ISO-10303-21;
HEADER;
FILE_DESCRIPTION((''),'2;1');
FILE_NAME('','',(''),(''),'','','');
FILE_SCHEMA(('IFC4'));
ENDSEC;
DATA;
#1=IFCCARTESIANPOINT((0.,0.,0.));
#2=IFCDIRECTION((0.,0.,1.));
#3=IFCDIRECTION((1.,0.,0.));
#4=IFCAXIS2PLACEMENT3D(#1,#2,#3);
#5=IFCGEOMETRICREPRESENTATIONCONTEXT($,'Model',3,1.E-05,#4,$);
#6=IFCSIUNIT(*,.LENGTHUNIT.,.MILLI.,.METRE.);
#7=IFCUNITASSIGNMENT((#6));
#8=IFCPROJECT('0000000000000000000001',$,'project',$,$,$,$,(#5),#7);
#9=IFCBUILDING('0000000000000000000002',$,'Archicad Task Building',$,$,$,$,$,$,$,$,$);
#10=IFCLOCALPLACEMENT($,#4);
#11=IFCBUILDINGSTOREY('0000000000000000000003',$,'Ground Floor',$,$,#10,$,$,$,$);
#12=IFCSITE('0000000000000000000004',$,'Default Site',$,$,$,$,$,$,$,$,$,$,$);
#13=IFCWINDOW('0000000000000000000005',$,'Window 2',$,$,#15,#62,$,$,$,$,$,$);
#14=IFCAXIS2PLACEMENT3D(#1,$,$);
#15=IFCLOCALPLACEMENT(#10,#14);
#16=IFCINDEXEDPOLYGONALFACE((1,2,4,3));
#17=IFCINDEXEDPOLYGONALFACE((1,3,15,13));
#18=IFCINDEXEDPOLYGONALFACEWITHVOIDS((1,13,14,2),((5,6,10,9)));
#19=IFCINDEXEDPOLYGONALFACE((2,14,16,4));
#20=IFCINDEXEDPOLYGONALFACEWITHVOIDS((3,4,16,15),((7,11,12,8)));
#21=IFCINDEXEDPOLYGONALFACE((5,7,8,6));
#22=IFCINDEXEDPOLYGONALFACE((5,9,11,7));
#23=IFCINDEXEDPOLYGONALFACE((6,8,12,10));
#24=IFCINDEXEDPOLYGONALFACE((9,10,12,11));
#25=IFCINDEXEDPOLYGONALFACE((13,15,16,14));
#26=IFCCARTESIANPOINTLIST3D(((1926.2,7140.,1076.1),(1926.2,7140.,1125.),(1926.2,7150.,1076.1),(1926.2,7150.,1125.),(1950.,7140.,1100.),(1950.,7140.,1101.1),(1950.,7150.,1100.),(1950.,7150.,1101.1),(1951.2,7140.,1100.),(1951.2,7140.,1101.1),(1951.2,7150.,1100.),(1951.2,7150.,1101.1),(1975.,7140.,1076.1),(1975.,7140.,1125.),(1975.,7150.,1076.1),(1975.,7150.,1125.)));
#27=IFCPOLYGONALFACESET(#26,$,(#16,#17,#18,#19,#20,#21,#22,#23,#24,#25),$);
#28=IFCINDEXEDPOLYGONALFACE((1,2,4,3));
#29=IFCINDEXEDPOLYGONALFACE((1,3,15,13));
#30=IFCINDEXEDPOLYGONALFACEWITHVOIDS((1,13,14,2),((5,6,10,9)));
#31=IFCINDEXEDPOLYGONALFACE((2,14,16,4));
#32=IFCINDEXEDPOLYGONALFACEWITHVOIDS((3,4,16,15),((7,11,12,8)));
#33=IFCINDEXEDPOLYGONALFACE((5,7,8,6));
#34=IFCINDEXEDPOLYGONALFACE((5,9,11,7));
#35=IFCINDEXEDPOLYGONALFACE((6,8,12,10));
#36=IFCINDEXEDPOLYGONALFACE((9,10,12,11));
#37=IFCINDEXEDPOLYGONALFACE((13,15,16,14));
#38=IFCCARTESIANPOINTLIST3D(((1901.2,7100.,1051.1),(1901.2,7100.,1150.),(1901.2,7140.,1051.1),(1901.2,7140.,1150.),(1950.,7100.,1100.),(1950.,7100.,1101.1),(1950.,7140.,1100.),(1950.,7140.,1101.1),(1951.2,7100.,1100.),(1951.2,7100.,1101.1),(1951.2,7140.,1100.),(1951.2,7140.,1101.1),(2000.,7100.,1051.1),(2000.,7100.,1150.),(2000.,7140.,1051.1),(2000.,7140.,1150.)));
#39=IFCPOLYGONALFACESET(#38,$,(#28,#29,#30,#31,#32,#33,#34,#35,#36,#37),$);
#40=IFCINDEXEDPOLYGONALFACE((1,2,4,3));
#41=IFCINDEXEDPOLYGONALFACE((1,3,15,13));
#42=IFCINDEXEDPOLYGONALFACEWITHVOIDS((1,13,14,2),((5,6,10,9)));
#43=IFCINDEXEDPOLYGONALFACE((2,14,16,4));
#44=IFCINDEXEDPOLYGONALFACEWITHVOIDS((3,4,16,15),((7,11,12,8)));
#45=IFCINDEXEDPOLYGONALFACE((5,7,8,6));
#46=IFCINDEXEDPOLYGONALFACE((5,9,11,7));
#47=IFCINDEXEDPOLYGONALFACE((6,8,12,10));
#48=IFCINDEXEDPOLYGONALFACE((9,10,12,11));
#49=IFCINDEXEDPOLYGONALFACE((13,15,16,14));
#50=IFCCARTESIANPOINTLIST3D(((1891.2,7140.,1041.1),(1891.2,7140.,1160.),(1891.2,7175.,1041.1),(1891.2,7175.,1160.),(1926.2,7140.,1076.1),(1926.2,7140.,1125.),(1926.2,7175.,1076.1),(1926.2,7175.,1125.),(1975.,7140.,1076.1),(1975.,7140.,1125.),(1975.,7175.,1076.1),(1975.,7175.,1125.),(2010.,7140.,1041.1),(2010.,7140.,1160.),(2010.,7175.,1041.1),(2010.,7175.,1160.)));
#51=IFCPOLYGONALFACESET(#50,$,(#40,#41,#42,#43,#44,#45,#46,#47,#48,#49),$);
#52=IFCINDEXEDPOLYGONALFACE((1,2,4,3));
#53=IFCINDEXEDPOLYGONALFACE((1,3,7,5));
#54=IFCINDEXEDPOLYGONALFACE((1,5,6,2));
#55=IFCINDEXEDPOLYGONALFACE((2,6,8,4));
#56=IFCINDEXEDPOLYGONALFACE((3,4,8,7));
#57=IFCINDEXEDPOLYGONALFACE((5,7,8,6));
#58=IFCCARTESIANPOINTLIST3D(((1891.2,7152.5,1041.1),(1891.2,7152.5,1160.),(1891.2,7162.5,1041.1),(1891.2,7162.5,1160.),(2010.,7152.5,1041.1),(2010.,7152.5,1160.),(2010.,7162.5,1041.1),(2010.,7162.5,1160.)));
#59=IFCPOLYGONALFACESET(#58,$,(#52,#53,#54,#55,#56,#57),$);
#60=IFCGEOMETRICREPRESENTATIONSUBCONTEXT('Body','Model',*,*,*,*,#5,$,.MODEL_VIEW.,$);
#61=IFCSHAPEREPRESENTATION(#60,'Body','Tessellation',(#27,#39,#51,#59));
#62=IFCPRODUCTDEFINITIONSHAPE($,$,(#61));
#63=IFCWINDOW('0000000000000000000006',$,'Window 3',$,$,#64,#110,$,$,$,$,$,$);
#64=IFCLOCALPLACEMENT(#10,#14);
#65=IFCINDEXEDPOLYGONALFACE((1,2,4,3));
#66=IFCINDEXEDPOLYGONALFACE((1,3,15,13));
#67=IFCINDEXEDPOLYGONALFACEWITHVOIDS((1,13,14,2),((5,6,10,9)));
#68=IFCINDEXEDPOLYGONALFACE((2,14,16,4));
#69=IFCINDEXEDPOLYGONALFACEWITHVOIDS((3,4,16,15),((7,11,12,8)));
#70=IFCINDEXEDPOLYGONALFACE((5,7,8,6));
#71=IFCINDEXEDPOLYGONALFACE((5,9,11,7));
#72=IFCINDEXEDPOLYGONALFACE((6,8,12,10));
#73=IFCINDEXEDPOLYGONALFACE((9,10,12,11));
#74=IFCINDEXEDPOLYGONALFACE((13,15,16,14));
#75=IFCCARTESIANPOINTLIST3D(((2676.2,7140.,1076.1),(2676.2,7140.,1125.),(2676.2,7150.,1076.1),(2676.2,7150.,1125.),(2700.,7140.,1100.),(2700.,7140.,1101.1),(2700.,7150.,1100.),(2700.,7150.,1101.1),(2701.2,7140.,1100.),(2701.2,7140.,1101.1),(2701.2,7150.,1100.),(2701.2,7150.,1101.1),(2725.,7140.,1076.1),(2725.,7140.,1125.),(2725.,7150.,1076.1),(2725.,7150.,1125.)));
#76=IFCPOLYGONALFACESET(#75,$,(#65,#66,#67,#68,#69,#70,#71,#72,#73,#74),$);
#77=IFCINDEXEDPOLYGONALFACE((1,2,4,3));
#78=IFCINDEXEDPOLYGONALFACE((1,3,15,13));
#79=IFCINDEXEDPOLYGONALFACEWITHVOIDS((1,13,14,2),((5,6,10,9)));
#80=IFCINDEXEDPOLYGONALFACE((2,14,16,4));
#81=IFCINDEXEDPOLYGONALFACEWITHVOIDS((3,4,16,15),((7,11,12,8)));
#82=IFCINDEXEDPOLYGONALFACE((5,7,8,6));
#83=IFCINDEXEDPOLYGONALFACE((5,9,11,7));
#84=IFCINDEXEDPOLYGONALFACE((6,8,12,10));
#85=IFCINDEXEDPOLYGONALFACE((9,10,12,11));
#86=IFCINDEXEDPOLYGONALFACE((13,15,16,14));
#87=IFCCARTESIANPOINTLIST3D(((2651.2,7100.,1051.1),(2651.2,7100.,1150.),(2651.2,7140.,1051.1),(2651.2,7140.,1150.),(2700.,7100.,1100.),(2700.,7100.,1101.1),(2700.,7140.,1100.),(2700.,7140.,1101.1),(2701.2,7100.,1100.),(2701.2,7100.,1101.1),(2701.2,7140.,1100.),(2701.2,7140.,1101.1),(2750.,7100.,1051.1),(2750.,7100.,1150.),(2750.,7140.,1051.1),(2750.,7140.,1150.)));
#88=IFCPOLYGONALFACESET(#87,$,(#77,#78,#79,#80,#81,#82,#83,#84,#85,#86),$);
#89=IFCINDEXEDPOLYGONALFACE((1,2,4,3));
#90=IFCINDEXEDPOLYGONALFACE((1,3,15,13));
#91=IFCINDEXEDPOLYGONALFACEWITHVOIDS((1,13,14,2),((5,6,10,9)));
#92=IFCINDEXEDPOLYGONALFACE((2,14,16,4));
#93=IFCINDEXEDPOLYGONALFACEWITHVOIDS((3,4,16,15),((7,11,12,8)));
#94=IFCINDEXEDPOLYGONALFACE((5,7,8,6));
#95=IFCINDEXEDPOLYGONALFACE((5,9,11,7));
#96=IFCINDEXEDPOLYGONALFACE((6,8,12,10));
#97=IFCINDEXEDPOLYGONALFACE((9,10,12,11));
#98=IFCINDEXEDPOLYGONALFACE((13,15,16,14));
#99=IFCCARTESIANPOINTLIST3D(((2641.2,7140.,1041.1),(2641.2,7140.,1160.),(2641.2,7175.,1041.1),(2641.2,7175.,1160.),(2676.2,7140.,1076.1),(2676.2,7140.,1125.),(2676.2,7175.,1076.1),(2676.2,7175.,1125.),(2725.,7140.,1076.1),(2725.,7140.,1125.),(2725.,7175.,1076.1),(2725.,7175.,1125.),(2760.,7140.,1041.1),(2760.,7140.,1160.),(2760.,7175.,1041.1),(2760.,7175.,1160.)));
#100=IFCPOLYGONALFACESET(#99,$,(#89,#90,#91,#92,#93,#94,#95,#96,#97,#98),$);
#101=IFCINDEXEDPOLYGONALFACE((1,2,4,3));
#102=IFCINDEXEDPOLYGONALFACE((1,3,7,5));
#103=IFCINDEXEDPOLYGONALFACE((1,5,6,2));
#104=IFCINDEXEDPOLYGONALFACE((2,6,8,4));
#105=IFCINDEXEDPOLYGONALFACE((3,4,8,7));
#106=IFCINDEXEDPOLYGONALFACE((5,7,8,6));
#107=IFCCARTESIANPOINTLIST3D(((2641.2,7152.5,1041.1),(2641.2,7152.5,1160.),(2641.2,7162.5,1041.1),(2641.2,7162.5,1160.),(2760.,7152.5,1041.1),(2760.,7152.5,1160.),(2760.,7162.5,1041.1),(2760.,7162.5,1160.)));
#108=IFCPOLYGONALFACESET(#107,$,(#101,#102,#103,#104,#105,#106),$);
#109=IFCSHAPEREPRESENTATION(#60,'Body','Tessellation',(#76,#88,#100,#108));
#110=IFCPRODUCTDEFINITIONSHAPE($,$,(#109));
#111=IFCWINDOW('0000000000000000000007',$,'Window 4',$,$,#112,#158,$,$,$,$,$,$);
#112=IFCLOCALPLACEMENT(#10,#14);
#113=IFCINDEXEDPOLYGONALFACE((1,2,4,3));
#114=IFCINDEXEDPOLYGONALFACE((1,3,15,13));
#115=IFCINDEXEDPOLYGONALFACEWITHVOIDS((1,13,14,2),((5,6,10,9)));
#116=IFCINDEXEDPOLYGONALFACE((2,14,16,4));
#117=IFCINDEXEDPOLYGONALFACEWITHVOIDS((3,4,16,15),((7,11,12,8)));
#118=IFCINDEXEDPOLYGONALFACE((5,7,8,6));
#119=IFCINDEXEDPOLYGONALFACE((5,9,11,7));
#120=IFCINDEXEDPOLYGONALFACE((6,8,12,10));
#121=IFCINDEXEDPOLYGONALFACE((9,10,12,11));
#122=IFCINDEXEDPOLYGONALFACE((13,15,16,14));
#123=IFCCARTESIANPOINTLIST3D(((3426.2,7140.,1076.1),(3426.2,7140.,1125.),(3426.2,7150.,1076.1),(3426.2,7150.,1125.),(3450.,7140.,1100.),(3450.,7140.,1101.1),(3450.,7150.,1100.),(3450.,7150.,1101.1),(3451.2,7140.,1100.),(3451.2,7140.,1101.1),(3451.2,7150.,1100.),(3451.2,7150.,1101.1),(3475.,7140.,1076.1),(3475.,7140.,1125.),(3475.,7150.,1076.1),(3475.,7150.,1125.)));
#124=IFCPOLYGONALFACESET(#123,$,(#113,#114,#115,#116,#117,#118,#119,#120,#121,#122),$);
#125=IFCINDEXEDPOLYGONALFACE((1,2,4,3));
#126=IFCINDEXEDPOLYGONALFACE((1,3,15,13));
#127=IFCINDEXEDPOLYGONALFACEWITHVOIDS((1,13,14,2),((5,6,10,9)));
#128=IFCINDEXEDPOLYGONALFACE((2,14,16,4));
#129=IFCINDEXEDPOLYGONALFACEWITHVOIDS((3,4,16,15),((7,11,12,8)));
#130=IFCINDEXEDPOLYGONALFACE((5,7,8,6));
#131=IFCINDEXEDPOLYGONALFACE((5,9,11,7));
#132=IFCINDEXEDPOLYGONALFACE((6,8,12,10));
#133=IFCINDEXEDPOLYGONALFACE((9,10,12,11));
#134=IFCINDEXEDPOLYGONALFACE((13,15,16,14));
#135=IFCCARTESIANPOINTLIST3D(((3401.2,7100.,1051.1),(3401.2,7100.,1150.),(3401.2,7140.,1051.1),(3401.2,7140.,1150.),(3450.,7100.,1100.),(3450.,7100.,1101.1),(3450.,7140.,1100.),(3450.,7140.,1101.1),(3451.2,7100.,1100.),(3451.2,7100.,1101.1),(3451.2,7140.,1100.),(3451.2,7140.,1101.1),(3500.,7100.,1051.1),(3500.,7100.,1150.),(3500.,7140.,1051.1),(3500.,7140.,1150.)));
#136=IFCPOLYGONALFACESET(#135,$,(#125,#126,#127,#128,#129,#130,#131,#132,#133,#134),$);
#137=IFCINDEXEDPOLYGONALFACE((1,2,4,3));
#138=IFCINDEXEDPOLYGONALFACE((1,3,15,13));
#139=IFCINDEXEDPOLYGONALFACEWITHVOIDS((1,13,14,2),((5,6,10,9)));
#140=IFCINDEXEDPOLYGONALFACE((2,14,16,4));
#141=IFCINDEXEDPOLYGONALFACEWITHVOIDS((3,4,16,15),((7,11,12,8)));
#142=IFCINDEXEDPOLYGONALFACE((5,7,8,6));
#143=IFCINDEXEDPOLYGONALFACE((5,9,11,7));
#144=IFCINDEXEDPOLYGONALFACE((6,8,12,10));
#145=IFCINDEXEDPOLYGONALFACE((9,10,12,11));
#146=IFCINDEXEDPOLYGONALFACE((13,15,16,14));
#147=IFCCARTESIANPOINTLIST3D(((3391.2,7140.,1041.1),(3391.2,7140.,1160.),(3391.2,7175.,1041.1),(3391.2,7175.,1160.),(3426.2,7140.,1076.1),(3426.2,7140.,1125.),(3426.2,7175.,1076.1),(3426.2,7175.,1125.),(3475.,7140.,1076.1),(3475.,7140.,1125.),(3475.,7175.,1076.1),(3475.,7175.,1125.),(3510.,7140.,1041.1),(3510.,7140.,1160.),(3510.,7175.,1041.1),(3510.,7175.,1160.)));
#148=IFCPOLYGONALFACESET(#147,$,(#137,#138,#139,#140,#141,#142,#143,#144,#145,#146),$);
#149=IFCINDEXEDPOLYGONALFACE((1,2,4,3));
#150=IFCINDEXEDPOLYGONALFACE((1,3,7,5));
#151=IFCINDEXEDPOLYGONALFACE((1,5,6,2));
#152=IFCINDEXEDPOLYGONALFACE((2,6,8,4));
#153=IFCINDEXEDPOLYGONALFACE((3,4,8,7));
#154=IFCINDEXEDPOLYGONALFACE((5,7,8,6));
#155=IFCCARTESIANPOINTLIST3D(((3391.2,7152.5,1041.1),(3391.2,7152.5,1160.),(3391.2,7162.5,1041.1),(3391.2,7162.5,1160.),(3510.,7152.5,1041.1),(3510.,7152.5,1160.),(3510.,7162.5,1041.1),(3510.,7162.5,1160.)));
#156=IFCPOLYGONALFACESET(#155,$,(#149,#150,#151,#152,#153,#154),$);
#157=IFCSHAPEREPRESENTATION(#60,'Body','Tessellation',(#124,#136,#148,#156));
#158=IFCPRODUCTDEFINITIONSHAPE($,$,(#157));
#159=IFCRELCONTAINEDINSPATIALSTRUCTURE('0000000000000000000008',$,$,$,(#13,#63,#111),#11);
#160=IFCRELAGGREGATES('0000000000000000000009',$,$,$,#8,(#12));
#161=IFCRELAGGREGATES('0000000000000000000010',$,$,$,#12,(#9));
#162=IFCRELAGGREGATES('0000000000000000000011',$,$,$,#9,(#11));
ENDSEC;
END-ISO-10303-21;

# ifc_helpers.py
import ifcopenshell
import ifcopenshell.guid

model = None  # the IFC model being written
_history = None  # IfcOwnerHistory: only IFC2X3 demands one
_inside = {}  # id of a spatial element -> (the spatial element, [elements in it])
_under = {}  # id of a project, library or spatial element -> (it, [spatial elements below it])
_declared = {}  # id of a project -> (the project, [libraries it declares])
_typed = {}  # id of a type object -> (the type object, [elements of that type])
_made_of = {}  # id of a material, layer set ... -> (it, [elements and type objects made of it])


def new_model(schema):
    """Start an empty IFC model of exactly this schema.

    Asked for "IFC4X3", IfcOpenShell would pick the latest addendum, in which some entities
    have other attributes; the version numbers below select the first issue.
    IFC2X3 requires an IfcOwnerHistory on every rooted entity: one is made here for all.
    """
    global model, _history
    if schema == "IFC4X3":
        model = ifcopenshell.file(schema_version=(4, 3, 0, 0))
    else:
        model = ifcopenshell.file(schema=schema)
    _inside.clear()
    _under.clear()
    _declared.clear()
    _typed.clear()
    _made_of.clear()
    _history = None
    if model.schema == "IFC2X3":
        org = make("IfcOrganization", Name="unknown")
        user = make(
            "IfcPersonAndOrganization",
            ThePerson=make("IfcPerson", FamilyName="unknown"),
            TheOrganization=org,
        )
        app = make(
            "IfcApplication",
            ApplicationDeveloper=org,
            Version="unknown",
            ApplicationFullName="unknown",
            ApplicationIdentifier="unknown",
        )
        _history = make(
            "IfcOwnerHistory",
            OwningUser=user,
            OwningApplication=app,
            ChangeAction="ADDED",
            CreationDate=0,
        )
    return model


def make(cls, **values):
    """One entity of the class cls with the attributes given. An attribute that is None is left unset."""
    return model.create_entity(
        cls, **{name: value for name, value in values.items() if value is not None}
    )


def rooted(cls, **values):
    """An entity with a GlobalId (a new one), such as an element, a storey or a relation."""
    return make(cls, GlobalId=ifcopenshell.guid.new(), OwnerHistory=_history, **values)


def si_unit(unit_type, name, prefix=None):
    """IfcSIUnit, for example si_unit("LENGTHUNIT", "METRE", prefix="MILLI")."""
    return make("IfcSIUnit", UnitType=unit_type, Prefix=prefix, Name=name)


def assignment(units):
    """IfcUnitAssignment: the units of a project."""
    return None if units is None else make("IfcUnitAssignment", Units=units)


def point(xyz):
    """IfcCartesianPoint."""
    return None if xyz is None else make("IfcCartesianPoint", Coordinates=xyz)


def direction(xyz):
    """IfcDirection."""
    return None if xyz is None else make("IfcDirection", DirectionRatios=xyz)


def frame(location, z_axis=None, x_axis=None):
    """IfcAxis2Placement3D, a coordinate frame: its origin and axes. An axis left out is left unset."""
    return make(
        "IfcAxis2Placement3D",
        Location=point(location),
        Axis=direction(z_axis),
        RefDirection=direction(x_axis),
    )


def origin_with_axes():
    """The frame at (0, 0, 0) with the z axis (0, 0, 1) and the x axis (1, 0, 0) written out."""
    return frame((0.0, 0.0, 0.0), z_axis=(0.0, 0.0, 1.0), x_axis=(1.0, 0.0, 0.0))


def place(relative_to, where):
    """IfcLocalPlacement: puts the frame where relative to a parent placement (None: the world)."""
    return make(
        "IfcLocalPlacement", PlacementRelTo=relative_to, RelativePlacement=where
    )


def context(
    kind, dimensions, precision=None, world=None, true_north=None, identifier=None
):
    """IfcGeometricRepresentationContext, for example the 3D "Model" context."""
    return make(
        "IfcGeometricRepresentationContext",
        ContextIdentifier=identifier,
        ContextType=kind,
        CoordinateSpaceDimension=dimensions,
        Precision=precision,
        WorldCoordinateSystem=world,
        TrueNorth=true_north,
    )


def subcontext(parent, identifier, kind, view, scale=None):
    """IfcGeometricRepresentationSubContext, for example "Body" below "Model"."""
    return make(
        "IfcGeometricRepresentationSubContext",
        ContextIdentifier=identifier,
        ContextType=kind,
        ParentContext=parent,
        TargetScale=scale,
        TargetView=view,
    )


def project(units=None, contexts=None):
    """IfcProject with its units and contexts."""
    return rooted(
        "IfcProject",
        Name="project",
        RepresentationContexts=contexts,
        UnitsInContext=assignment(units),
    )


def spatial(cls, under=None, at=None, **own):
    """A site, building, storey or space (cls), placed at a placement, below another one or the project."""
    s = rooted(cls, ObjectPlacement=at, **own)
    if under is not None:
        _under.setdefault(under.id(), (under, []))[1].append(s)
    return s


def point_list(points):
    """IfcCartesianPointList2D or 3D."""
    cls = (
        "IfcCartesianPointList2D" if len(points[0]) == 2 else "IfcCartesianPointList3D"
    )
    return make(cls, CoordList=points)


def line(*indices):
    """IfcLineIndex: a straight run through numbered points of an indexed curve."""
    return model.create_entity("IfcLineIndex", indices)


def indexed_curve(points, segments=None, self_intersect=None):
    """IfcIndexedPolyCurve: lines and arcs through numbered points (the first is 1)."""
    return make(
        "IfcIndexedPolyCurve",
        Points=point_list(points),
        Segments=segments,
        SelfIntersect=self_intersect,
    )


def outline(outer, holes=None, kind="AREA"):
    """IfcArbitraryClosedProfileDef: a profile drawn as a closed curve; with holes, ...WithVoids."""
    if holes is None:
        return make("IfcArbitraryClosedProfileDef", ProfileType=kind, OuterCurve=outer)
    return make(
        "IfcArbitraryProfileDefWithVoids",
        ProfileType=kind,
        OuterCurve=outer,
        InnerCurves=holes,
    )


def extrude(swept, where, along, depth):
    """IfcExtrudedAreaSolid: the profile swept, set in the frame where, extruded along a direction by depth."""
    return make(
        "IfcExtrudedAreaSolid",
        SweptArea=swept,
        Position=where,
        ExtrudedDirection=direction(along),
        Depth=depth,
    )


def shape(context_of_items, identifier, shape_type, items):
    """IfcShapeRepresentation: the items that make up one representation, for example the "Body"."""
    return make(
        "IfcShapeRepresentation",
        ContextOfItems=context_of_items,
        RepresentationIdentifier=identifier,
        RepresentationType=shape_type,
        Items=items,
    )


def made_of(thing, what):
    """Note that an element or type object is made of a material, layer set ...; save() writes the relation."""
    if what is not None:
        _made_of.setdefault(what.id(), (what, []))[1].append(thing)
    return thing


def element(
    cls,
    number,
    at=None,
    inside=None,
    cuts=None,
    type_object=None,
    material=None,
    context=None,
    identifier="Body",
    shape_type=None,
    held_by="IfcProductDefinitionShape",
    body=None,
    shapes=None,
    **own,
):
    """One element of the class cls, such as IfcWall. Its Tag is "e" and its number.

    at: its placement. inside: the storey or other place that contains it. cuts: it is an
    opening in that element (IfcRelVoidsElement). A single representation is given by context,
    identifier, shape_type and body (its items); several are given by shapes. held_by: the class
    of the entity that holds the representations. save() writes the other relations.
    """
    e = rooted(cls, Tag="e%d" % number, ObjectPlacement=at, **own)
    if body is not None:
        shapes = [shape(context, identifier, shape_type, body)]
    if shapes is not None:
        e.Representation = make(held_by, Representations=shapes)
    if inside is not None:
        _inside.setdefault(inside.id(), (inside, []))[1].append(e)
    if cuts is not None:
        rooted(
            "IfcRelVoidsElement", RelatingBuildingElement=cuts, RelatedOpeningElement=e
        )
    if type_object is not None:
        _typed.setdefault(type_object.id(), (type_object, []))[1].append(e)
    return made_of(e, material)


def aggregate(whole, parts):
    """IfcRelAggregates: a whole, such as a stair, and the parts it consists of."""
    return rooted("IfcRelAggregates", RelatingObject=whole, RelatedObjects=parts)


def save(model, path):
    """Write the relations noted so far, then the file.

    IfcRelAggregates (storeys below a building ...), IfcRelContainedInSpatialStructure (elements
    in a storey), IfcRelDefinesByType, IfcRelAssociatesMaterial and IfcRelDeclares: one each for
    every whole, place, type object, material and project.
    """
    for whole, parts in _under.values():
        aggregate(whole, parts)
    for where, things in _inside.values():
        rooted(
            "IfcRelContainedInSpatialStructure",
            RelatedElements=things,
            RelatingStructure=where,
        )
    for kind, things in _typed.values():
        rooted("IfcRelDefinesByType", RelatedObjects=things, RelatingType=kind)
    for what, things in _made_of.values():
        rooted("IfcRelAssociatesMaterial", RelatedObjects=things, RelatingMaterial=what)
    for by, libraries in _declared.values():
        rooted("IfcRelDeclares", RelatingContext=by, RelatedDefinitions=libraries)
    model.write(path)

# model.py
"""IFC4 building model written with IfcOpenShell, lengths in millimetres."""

from ifc_helpers import new_model, si_unit, frame, origin_with_axes, place, context, subcontext, project, spatial, line, indexed_curve, outline, extrude, element, save


model = new_model("IFC4")

# Units and contexts
model_context = context("Model", 3, precision=1e-05, world=origin_with_axes())
body_context = subcontext(model_context, "Body", "Model", "MODEL_VIEW")
ifc_project = project(units=[si_unit("LENGTHUNIT", "METRE", prefix="MILLI")], contexts=[model_context])

# Site, building, storey
site = spatial("IfcSite", under=ifc_project, Name="Default Site")
building = spatial("IfcBuilding", under=site, Name="Archicad Task Building")
storey_placement = place(None, origin_with_axes())
storey = spatial("IfcBuildingStorey", under=building, at=storey_placement, Name="Ground Floor")

# Windows
for number, where, z_axis, x_axis, name in (
    (1, (1950.0, 7050.0, 1100.0), (0.0, 0.0, 1.0), (1.0, 0.0, 0.0), "Window 2"),
    (2, (2700.0, 7050.0, 1100.0), (0.0, 0.0, 1.0), (1.0, 0.0, 0.0), "Window 3"),
    (3, (3450.0, 7050.0, 1100.0), (0.0, 0.0, 1.0), (1.0, 0.0, 0.0), "Window 4"),
):
    element("IfcWindow", number, at=place(storey_placement, frame(where, z_axis=z_axis, x_axis=x_axis)), inside=storey, Name=name, context=body_context, shape_type="SweptSolid", body=[
        extrude(outline(indexed_curve([(0.0, 0.0), (1.2, 0.0), (1.2, 1.1), (0.0, 1.1)], segments=[line(1, 2, 3, 4, 1)]), holes=[indexed_curve([(25.0, 25.0), (-23.8, 25.0), (-23.8, -23.9), (25.0, -23.9)], segments=[line(1, 2, 3, 4, 1)])]), frame((0.0, 90.0, 0.0), z_axis=(0.0, -1.0, 0.0), x_axis=(1.0, 0.0, 0.0)), (0.0, 0.0, -1.0), 10.0),
        extrude(outline(indexed_curve([(0.0, 0.0), (1.2, 0.0), (1.2, 1.1), (0.0, 1.1)], segments=[line(1, 2, 3, 4, 1)]), holes=[indexed_curve([(50.0, 50.0), (-48.8, 50.0), (-48.8, -48.9), (50.0, -48.9)], segments=[line(1, 2, 3, 4, 1)])]), frame((0.0, 50.0, 0.0), z_axis=(0.0, -1.0, 0.0), x_axis=(1.0, 0.0, 0.0)), (0.0, 0.0, -1.0), 40.0),
        extrude(outline(indexed_curve([(0.0, 0.0), (-48.8, 0.0), (-48.8, -48.9), (0.0, -48.9)], segments=[line(1, 2, 3, 4, 1)]), holes=[indexed_curve([(35.0, 35.0), (-83.8, 35.0), (-83.8, -83.9), (35.0, -83.9)], segments=[line(1, 2, 3, 4, 1)])]), frame((25.0, 90.0, 25.0), z_axis=(0.0, -1.0, 0.0), x_axis=(1.0, 0.0, 0.0)), (0.0, 0.0, -1.0), 35.0),
        extrude(outline(indexed_curve([(35.0, 35.0), (-83.8, 35.0), (-83.8, -83.9), (35.0, -83.9)], segments=[line(1, 2, 3, 4, 1)])), frame((25.0, 102.5, 25.0), z_axis=(0.0, -1.0, 0.0), x_axis=(1.0, 0.0, 0.0)), (0.0, 0.0, -1.0), 10.0),
    ])

save(model, "model.ifc")
